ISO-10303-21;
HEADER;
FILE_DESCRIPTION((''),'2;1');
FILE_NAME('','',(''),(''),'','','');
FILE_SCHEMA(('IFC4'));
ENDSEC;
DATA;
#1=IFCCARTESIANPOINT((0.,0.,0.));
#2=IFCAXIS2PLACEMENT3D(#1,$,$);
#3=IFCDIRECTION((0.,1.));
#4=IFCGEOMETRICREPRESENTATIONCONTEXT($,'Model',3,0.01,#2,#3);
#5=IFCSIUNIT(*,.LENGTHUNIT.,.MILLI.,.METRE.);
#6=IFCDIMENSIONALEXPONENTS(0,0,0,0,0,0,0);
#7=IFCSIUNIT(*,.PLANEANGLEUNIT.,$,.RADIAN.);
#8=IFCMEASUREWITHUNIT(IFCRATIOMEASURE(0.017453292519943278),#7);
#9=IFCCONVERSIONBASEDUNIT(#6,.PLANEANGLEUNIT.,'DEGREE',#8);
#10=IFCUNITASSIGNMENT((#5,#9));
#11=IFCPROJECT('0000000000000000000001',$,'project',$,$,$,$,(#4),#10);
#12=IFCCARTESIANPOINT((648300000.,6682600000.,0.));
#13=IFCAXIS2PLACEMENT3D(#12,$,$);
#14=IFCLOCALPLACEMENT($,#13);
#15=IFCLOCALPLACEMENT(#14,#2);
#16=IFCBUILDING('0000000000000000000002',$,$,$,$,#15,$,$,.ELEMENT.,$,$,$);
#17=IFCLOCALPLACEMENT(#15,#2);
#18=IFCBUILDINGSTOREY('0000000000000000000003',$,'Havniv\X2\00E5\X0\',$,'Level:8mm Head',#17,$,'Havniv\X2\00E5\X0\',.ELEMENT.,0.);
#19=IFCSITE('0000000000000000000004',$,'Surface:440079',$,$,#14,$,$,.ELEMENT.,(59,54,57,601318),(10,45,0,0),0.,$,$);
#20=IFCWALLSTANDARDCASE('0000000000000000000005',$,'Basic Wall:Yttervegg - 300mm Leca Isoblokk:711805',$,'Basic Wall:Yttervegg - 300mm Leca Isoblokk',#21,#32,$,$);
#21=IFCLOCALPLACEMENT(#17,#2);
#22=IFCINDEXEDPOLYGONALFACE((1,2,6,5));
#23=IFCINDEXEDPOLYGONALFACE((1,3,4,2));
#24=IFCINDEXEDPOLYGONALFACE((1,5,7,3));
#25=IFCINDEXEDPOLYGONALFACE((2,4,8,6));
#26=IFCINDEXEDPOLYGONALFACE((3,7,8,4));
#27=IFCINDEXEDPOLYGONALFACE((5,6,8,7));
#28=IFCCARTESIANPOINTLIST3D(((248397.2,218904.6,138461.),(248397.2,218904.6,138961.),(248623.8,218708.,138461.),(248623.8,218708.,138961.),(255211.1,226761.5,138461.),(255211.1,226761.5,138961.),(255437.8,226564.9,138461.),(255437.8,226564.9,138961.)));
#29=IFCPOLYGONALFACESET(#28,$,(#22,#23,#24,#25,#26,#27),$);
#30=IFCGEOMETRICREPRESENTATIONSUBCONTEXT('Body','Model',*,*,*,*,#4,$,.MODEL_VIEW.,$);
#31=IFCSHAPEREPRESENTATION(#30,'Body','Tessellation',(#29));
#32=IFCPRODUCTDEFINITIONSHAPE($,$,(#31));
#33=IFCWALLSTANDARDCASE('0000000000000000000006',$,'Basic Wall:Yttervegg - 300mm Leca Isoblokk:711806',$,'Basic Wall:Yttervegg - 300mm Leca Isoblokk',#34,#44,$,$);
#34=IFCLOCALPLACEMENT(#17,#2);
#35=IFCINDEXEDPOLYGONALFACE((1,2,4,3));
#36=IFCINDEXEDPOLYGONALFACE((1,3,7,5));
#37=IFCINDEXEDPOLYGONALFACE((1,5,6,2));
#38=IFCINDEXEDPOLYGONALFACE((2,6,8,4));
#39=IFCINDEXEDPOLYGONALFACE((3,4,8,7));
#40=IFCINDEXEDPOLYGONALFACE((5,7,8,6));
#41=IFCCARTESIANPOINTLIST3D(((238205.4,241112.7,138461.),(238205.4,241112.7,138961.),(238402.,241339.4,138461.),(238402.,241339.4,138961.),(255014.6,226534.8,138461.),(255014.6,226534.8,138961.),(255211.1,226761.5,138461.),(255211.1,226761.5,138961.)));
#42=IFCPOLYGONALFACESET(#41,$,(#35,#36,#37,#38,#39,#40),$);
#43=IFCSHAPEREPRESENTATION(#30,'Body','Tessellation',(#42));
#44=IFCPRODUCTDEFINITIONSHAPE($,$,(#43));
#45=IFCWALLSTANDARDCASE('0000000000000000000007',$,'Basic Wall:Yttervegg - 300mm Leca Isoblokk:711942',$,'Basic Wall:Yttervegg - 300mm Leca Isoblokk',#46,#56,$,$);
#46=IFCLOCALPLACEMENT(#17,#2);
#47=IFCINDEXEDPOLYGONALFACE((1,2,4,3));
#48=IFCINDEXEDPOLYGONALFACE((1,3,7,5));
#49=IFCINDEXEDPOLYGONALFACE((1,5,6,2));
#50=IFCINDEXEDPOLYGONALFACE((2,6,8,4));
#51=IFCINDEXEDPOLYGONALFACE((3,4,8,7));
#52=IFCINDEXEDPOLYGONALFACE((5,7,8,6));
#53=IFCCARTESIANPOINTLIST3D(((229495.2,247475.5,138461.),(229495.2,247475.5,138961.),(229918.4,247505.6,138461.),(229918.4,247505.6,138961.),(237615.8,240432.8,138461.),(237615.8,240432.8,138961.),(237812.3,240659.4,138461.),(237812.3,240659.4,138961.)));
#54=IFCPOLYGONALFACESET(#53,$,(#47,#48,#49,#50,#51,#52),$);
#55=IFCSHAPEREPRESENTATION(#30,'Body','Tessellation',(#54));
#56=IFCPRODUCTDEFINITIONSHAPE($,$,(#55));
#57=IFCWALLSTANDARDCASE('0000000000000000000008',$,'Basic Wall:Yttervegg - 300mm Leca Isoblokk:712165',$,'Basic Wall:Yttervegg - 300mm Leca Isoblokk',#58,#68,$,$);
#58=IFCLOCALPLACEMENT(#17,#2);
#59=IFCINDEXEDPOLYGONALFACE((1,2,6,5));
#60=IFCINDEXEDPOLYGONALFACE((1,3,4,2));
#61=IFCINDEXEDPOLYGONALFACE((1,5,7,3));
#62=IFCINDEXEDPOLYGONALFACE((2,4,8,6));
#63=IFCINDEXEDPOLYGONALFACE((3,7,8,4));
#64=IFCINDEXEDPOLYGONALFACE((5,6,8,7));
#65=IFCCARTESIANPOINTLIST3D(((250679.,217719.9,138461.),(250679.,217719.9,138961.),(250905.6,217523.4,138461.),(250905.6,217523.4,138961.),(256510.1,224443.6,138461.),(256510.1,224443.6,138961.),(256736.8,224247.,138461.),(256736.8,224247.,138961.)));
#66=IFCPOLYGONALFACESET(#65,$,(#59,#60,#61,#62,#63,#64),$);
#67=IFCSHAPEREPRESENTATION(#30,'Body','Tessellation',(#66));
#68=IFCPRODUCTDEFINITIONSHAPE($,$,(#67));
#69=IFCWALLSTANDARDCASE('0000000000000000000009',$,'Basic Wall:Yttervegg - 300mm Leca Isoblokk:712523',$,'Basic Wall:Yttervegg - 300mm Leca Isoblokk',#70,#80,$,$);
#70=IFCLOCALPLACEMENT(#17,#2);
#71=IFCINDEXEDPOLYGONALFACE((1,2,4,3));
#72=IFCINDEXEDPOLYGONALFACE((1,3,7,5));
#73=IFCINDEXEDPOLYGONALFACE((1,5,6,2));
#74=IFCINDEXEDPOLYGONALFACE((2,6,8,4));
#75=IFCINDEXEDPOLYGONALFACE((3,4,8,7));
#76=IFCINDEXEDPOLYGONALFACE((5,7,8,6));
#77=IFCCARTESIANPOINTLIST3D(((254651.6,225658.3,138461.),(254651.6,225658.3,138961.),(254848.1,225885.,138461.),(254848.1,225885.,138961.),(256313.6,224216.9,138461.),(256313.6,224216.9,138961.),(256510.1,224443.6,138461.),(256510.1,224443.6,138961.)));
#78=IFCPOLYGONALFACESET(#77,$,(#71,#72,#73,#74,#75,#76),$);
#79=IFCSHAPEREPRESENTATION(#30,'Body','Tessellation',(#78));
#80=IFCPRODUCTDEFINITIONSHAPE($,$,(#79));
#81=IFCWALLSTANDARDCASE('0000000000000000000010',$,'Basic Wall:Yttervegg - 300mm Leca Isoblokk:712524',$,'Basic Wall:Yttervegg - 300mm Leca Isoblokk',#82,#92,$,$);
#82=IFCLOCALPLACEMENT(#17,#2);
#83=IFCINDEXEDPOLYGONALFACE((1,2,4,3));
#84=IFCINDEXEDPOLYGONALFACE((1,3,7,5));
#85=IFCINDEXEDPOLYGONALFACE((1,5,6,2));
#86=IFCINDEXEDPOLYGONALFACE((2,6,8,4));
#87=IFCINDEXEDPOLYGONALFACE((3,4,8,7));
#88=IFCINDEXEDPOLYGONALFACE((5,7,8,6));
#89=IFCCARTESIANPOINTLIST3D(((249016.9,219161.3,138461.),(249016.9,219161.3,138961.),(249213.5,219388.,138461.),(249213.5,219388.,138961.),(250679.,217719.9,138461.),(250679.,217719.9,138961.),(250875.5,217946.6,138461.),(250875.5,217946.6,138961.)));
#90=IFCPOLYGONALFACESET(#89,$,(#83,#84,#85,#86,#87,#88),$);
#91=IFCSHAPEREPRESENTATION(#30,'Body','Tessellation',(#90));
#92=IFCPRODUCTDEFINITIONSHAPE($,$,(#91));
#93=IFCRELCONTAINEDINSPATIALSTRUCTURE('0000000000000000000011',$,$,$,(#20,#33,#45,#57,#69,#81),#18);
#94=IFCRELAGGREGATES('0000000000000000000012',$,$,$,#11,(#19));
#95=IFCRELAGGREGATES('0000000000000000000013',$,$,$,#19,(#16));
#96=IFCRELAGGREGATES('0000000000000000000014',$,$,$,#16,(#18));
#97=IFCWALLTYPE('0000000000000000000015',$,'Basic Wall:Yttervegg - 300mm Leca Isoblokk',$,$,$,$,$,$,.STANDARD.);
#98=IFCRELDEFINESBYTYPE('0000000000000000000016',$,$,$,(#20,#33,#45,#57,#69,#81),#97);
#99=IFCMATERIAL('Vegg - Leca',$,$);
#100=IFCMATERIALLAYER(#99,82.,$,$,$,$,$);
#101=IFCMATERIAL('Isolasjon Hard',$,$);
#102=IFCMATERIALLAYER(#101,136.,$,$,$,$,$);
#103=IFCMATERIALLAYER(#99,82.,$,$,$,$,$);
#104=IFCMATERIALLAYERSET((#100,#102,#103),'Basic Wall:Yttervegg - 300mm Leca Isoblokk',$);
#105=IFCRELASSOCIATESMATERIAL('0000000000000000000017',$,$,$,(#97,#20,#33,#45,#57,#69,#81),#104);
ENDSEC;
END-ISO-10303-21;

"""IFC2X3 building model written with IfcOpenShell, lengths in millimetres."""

from ifc_helpers import new_model, entity, si_unit, converted_unit, direction, frame, frame_2d, origin, place, context, subcontext, project, spatial, polyline, rectangle, outline, extrude, material, layer, layer_set, layer_usage, type_object, element, save


model = new_model("IFC2X3")

# Units and contexts
model_context = context("Model", 3, precision=0.01, world=origin(), true_north=direction((0.0, 1.0)))
body_context = subcontext(model_context, "Body", "Model", "MODEL_VIEW")
ifc_project = project(units=[si_unit("LENGTHUNIT", "METRE", prefix="MILLI"), converted_unit("PLANEANGLEUNIT", "DEGREE", entity("IfcRatioMeasure", 0.017453292519943278), si_unit("PLANEANGLEUNIT", "RADIAN"), dimensions=[0, 0, 0, 0, 0, 0, 0])], contexts=[model_context])

# Site, building, storey
site_placement = place(None, frame((648300000.0, 6682600000.0, 0.0)))
site = spatial("IfcSite", under=ifc_project, at=site_placement, Name="Surface:440079", CompositionType="ELEMENT", RefLatitude=(59, 54, 57, 601318), RefLongitude=(10, 45, 0, 0), RefElevation=0.0)
building_placement = place(site_placement, origin())
building = spatial("IfcBuilding", under=site, at=building_placement, CompositionType="ELEMENT")
storey_placement = place(building_placement, origin())
storey = spatial("IfcBuildingStorey", under=building, at=storey_placement, Name="Havnivå", ObjectType="Level:8mm Head", LongName="Havnivå", CompositionType="ELEMENT", Elevation=0.0)

# Walls
ifc_material_1 = material(Name="Vegg - Leca")
ifc_layer_1 = layer(ifc_material_1, 82.0)
ifc_material_2 = material(Name="Isolasjon Hard")
ifc_layer_2 = layer(ifc_material_2, 136.0)
ifc_layer_3 = layer(ifc_material_1, 82.0)
ifc_layer_set_1 = layer_set([ifc_layer_1, ifc_layer_2, ifc_layer_3], Name="Basic Wall:Yttervegg - 300mm Leca Isoblokk")
ifc_layer_usage_1 = layer_usage(ifc_layer_set_1, "AXIS2", "POSITIVE", -150.0)
wall_type_1 = type_object("IfcWallType", Name="Basic Wall:Yttervegg - 300mm Leca Isoblokk", PredefinedType="STANDARD", material=ifc_layer_set_1)
wall_1_placement = place(storey_placement, frame((248510.5, 218806.3, 138461.0), z_axis=(0.0, 0.0, 1.0), x_axis=(0.655187, 0.755467, 0.0)))
element("IfcWallStandardCase", 1, at=wall_1_placement, inside=storey, type_object=wall_type_1, material=ifc_layer_usage_1, Name="Basic Wall:Yttervegg - 300mm Leca Isoblokk:711805", ObjectType="Basic Wall:Yttervegg - 300mm Leca Isoblokk", context=body_context, shape_type="SweptSolid", body=[
    extrude(rectangle(XDim=10400.0, YDim=300.0, at=frame_2d((5200.0, 0.0), x_axis=(-1.0, 0.0))), origin(), (0.0, 0.0, 1.0), 500.0),
])
ifc_layer_usage_2 = layer_usage(ifc_layer_set_1, "AXIS2", "POSITIVE", -150.0)
wall_2_placement = place(storey_placement, frame((255112.9, 226648.1, 138461.0), z_axis=(0.0, 0.0, 1.0), x_axis=(-0.755467, 0.655187, 0.0)))
element("IfcWallStandardCase", 2, at=wall_2_placement, inside=storey, type_object=wall_type_1, material=ifc_layer_usage_2, Name="Basic Wall:Yttervegg - 300mm Leca Isoblokk:711806", ObjectType="Basic Wall:Yttervegg - 300mm Leca Isoblokk", context=body_context, shape_type="SweptSolid", body=[
    extrude(rectangle(XDim=22250.0, YDim=300.0, at=frame_2d((11125.0, 0.0), x_axis=(-1.0, 0.0))), origin(), (0.0, 0.0, 1.0), 500.0),
])
ifc_layer_usage_3 = layer_usage(ifc_layer_set_1, "AXIS2", "POSITIVE", -150.0)
wall_3_placement = place(storey_placement, frame((237714.1, 240546.1, 138461.0), z_axis=(0.0, 0.0, 1.0), x_axis=(-0.755467, 0.655187, 0.0)))
element("IfcWallStandardCase", 3, at=wall_3_placement, inside=storey, type_object=wall_type_1, material=ifc_layer_usage_3, Name="Basic Wall:Yttervegg - 300mm Leca Isoblokk:711942", ObjectType="Basic Wall:Yttervegg - 300mm Leca Isoblokk", context=body_context, shape_type="SweptSolid", body=[
    extrude(outline(polyline([(10449.1, -150.0), (10749.1, 150.0), (0.0, 150.0), (0.0, -150.0), (10449.1, -150.0)])), origin(), (0.0, 0.0, 1.0), 500.0),
])
ifc_layer_usage_4 = layer_usage(ifc_layer_set_1, "AXIS2", "POSITIVE", -150.0)
wall_4_placement = place(storey_placement, frame((250792.3, 217621.6, 138461.0), z_axis=(0.0, 0.0, 1.0), x_axis=(0.655187, 0.755467, 0.0)))
element("IfcWallStandardCase", 4, at=wall_4_placement, inside=storey, type_object=wall_type_1, material=ifc_layer_usage_4, Name="Basic Wall:Yttervegg - 300mm Leca Isoblokk:712165", ObjectType="Basic Wall:Yttervegg - 300mm Leca Isoblokk", context=body_context, shape_type="SweptSolid", body=[
    extrude(rectangle(XDim=8900.0, YDim=300.0, at=frame_2d((4450.0, 0.0), x_axis=(-1.0, 0.0))), origin(), (0.0, 0.0, 1.0), 500.0),
])
ifc_layer_usage_5 = layer_usage(ifc_layer_set_1, "AXIS2", "POSITIVE", -150.0)
wall_5_placement = place(storey_placement, frame((256411.9, 224330.2, 138461.0), z_axis=(0.0, 0.0, 1.0), x_axis=(-0.755467, 0.655187, 0.0)))
element("IfcWallStandardCase", 5, at=wall_5_placement, inside=storey, type_object=wall_type_1, material=ifc_layer_usage_5, Name="Basic Wall:Yttervegg - 300mm Leca Isoblokk:712523", ObjectType="Basic Wall:Yttervegg - 300mm Leca Isoblokk", context=body_context, shape_type="SweptSolid", body=[
    extrude(rectangle(XDim=2200.0, YDim=300.0, at=frame_2d((1100.0, 0.0), x_axis=(-1.0, 0.0))), origin(), (0.0, 0.0, 1.0), 500.0),
])
ifc_layer_usage_6 = layer_usage(ifc_layer_set_1, "AXIS2", "NEGATIVE", 150.0)
wall_6_placement = place(storey_placement, frame((250777.3, 217833.2, 138461.0), z_axis=(0.0, 0.0, 1.0), x_axis=(-0.755467, 0.655187, 0.0)))
element("IfcWallStandardCase", 6, at=wall_6_placement, inside=storey, type_object=wall_type_1, material=ifc_layer_usage_6, Name="Basic Wall:Yttervegg - 300mm Leca Isoblokk:712524", ObjectType="Basic Wall:Yttervegg - 300mm Leca Isoblokk", context=body_context, shape_type="SweptSolid", body=[
    extrude(rectangle(XDim=2200.0, YDim=300.0, at=frame_2d((1100.0, 0.0), x_axis=(-1.0, 0.0))), origin(), (0.0, 0.0, 1.0), 500.0),
])

save(model, "model.ifc")
